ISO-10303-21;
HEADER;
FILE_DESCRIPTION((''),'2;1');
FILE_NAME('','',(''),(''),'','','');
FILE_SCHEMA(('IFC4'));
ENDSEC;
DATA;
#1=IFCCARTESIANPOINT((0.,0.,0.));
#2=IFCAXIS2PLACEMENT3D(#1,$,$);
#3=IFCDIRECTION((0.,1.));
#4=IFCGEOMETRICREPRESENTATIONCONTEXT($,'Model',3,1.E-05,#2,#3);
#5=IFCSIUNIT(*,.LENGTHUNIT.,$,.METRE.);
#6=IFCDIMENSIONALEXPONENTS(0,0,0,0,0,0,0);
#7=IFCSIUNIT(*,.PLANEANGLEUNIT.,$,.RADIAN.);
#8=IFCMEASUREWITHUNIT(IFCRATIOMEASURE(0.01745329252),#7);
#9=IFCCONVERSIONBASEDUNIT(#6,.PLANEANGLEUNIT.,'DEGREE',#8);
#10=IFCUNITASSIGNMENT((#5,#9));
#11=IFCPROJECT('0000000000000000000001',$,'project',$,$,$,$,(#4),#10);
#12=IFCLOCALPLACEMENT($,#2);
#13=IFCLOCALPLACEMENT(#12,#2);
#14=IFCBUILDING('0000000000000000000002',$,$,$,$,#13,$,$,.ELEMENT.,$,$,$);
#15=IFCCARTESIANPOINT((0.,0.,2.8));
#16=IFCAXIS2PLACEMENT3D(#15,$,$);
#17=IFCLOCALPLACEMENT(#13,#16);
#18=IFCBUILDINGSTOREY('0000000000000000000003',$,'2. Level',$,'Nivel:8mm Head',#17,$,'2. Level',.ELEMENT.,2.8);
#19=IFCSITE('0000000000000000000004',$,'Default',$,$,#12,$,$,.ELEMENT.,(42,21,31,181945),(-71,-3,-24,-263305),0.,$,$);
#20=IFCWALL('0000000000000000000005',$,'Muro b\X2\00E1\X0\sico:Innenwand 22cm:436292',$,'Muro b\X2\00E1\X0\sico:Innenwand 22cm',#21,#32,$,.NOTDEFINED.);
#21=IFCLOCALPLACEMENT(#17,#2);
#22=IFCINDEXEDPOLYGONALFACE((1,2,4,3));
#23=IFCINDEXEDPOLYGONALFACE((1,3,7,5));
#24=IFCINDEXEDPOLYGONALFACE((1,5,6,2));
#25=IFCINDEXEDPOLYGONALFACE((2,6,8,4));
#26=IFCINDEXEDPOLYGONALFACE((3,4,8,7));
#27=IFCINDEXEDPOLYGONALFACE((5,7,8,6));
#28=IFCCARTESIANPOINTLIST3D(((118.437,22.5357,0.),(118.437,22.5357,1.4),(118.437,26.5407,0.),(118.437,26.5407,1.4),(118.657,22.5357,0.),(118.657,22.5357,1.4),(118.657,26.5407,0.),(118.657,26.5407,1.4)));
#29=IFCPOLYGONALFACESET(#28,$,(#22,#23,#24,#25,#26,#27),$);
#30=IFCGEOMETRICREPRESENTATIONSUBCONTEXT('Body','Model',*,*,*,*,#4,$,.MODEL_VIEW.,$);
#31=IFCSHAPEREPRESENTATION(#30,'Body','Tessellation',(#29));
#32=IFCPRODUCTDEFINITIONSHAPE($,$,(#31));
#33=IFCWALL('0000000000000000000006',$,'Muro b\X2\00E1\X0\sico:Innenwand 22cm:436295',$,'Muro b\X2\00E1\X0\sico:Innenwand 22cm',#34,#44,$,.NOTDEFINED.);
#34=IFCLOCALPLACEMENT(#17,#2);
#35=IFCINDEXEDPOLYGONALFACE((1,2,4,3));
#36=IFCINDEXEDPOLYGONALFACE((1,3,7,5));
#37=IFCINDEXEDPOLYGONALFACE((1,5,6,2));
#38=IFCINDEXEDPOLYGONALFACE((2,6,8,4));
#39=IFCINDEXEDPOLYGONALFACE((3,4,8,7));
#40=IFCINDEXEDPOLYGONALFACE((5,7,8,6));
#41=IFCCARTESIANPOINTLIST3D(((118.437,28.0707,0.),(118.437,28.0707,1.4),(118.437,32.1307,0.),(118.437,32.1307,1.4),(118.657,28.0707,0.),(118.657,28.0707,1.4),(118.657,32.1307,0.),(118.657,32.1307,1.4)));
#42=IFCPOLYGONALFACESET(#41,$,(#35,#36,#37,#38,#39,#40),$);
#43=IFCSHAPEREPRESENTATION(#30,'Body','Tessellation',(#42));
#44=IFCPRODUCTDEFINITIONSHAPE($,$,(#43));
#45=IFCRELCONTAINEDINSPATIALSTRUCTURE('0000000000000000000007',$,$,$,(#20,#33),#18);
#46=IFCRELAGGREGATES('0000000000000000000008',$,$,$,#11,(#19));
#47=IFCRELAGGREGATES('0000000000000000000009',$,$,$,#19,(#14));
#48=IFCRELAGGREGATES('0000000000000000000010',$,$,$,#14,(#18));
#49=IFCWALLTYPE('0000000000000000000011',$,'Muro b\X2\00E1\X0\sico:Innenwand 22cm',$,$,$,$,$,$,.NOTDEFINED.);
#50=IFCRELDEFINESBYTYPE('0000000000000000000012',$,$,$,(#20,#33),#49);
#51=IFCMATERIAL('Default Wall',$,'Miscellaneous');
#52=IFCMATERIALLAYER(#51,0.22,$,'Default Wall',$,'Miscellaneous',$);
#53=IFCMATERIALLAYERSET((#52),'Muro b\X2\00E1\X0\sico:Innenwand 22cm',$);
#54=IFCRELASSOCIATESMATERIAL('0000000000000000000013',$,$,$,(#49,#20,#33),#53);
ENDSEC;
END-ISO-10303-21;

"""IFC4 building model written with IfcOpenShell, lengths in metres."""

from ifc_helpers import new_model, entity, si_unit, converted_unit, direction, frame, frame_2d, origin, place, context, subcontext, project, spatial, rectangle, extrude, clip, halfspace, material, layer, layer_set, layer_usage, type_object, element, save


model = new_model("IFC4")

# Units and contexts
model_context = context("Model", 3, precision=1e-05, world=origin(), true_north=direction((0.0, 1.0)))
body_context = subcontext(model_context, "Body", "Model", "MODEL_VIEW")
ifc_project = project(units=[si_unit("LENGTHUNIT", "METRE"), converted_unit("PLANEANGLEUNIT", "DEGREE", entity("IfcRatioMeasure", 0.01745329252), si_unit("PLANEANGLEUNIT", "RADIAN"), dimensions=[0, 0, 0, 0, 0, 0, 0])], contexts=[model_context])

# Site, building, storey
site_placement = place(None, origin())
site = spatial("IfcSite", under=ifc_project, at=site_placement, Name="Default", CompositionType="ELEMENT", RefLatitude=(42, 21, 31, 181945), RefLongitude=(-71, -3, -24, -263305), RefElevation=0.0)
building_placement = place(site_placement, origin())
building = spatial("IfcBuilding", under=site, at=building_placement, CompositionType="ELEMENT")
storey_placement = place(building_placement, frame((0.0, 0.0, 2.8)))
storey = spatial("IfcBuildingStorey", under=building, at=storey_placement, Name="2. Level", ObjectType="Nivel:8mm Head", LongName="2. Level", CompositionType="ELEMENT", Elevation=2.8)

# Walls
ifc_material_1 = material(Name="Default Wall", Category="Miscellaneous")
ifc_layer_1 = layer(ifc_material_1, 0.22, Name="Default Wall", Category="Miscellaneous")
ifc_layer_set_1 = layer_set([ifc_layer_1], Name="Muro básico:Innenwand 22cm")
ifc_layer_usage_1 = layer_usage(ifc_layer_set_1, "AXIS2", "NEGATIVE", 0.11)
wall_type_1 = type_object("IfcWallType", Name="Muro básico:Innenwand 22cm", PredefinedType="NOTDEFINED", material=ifc_layer_set_1)
wall_1_placement = place(storey_placement, frame((118.547, 22.5357, 0.0), z_axis=(0.0, 0.0, 1.0), x_axis=(0.0, 1.0, 0.0)))
element("IfcWall", 1, at=wall_1_placement, inside=storey, type_object=wall_type_1, material=ifc_layer_usage_1, Name="Muro básico:Innenwand 22cm:436292", ObjectType="Muro básico:Innenwand 22cm", PredefinedType="NOTDEFINED", context=body_context, shape_type="Clipping", body=[
    clip(extrude(rectangle(XDim=4.005, YDim=0.22, at=frame_2d((2.0025, 0.0), x_axis=(-1.0, 0.0))), origin(), (0.0, 0.0, 1.0), 1.4), halfspace(origin(), True)),
])
ifc_layer_usage_2 = layer_usage(ifc_layer_set_1, "AXIS2", "NEGATIVE", 0.11)
wall_2_placement = place(storey_placement, frame((118.547, 28.0707, 0.0), z_axis=(0.0, 0.0, 1.0), x_axis=(0.0, 1.0, 0.0)))
element("IfcWall", 2, at=wall_2_placement, inside=storey, type_object=wall_type_1, material=ifc_layer_usage_2, Name="Muro básico:Innenwand 22cm:436295", ObjectType="Muro básico:Innenwand 22cm", PredefinedType="NOTDEFINED", context=body_context, shape_type="Clipping", body=[
    clip(extrude(rectangle(XDim=4.06, YDim=0.22, at=frame_2d((2.03, 0.0), x_axis=(-1.0, 0.0))), origin(), (0.0, 0.0, 1.0), 1.4), halfspace(origin(), True)),
])

save(model, "model.ifc")
